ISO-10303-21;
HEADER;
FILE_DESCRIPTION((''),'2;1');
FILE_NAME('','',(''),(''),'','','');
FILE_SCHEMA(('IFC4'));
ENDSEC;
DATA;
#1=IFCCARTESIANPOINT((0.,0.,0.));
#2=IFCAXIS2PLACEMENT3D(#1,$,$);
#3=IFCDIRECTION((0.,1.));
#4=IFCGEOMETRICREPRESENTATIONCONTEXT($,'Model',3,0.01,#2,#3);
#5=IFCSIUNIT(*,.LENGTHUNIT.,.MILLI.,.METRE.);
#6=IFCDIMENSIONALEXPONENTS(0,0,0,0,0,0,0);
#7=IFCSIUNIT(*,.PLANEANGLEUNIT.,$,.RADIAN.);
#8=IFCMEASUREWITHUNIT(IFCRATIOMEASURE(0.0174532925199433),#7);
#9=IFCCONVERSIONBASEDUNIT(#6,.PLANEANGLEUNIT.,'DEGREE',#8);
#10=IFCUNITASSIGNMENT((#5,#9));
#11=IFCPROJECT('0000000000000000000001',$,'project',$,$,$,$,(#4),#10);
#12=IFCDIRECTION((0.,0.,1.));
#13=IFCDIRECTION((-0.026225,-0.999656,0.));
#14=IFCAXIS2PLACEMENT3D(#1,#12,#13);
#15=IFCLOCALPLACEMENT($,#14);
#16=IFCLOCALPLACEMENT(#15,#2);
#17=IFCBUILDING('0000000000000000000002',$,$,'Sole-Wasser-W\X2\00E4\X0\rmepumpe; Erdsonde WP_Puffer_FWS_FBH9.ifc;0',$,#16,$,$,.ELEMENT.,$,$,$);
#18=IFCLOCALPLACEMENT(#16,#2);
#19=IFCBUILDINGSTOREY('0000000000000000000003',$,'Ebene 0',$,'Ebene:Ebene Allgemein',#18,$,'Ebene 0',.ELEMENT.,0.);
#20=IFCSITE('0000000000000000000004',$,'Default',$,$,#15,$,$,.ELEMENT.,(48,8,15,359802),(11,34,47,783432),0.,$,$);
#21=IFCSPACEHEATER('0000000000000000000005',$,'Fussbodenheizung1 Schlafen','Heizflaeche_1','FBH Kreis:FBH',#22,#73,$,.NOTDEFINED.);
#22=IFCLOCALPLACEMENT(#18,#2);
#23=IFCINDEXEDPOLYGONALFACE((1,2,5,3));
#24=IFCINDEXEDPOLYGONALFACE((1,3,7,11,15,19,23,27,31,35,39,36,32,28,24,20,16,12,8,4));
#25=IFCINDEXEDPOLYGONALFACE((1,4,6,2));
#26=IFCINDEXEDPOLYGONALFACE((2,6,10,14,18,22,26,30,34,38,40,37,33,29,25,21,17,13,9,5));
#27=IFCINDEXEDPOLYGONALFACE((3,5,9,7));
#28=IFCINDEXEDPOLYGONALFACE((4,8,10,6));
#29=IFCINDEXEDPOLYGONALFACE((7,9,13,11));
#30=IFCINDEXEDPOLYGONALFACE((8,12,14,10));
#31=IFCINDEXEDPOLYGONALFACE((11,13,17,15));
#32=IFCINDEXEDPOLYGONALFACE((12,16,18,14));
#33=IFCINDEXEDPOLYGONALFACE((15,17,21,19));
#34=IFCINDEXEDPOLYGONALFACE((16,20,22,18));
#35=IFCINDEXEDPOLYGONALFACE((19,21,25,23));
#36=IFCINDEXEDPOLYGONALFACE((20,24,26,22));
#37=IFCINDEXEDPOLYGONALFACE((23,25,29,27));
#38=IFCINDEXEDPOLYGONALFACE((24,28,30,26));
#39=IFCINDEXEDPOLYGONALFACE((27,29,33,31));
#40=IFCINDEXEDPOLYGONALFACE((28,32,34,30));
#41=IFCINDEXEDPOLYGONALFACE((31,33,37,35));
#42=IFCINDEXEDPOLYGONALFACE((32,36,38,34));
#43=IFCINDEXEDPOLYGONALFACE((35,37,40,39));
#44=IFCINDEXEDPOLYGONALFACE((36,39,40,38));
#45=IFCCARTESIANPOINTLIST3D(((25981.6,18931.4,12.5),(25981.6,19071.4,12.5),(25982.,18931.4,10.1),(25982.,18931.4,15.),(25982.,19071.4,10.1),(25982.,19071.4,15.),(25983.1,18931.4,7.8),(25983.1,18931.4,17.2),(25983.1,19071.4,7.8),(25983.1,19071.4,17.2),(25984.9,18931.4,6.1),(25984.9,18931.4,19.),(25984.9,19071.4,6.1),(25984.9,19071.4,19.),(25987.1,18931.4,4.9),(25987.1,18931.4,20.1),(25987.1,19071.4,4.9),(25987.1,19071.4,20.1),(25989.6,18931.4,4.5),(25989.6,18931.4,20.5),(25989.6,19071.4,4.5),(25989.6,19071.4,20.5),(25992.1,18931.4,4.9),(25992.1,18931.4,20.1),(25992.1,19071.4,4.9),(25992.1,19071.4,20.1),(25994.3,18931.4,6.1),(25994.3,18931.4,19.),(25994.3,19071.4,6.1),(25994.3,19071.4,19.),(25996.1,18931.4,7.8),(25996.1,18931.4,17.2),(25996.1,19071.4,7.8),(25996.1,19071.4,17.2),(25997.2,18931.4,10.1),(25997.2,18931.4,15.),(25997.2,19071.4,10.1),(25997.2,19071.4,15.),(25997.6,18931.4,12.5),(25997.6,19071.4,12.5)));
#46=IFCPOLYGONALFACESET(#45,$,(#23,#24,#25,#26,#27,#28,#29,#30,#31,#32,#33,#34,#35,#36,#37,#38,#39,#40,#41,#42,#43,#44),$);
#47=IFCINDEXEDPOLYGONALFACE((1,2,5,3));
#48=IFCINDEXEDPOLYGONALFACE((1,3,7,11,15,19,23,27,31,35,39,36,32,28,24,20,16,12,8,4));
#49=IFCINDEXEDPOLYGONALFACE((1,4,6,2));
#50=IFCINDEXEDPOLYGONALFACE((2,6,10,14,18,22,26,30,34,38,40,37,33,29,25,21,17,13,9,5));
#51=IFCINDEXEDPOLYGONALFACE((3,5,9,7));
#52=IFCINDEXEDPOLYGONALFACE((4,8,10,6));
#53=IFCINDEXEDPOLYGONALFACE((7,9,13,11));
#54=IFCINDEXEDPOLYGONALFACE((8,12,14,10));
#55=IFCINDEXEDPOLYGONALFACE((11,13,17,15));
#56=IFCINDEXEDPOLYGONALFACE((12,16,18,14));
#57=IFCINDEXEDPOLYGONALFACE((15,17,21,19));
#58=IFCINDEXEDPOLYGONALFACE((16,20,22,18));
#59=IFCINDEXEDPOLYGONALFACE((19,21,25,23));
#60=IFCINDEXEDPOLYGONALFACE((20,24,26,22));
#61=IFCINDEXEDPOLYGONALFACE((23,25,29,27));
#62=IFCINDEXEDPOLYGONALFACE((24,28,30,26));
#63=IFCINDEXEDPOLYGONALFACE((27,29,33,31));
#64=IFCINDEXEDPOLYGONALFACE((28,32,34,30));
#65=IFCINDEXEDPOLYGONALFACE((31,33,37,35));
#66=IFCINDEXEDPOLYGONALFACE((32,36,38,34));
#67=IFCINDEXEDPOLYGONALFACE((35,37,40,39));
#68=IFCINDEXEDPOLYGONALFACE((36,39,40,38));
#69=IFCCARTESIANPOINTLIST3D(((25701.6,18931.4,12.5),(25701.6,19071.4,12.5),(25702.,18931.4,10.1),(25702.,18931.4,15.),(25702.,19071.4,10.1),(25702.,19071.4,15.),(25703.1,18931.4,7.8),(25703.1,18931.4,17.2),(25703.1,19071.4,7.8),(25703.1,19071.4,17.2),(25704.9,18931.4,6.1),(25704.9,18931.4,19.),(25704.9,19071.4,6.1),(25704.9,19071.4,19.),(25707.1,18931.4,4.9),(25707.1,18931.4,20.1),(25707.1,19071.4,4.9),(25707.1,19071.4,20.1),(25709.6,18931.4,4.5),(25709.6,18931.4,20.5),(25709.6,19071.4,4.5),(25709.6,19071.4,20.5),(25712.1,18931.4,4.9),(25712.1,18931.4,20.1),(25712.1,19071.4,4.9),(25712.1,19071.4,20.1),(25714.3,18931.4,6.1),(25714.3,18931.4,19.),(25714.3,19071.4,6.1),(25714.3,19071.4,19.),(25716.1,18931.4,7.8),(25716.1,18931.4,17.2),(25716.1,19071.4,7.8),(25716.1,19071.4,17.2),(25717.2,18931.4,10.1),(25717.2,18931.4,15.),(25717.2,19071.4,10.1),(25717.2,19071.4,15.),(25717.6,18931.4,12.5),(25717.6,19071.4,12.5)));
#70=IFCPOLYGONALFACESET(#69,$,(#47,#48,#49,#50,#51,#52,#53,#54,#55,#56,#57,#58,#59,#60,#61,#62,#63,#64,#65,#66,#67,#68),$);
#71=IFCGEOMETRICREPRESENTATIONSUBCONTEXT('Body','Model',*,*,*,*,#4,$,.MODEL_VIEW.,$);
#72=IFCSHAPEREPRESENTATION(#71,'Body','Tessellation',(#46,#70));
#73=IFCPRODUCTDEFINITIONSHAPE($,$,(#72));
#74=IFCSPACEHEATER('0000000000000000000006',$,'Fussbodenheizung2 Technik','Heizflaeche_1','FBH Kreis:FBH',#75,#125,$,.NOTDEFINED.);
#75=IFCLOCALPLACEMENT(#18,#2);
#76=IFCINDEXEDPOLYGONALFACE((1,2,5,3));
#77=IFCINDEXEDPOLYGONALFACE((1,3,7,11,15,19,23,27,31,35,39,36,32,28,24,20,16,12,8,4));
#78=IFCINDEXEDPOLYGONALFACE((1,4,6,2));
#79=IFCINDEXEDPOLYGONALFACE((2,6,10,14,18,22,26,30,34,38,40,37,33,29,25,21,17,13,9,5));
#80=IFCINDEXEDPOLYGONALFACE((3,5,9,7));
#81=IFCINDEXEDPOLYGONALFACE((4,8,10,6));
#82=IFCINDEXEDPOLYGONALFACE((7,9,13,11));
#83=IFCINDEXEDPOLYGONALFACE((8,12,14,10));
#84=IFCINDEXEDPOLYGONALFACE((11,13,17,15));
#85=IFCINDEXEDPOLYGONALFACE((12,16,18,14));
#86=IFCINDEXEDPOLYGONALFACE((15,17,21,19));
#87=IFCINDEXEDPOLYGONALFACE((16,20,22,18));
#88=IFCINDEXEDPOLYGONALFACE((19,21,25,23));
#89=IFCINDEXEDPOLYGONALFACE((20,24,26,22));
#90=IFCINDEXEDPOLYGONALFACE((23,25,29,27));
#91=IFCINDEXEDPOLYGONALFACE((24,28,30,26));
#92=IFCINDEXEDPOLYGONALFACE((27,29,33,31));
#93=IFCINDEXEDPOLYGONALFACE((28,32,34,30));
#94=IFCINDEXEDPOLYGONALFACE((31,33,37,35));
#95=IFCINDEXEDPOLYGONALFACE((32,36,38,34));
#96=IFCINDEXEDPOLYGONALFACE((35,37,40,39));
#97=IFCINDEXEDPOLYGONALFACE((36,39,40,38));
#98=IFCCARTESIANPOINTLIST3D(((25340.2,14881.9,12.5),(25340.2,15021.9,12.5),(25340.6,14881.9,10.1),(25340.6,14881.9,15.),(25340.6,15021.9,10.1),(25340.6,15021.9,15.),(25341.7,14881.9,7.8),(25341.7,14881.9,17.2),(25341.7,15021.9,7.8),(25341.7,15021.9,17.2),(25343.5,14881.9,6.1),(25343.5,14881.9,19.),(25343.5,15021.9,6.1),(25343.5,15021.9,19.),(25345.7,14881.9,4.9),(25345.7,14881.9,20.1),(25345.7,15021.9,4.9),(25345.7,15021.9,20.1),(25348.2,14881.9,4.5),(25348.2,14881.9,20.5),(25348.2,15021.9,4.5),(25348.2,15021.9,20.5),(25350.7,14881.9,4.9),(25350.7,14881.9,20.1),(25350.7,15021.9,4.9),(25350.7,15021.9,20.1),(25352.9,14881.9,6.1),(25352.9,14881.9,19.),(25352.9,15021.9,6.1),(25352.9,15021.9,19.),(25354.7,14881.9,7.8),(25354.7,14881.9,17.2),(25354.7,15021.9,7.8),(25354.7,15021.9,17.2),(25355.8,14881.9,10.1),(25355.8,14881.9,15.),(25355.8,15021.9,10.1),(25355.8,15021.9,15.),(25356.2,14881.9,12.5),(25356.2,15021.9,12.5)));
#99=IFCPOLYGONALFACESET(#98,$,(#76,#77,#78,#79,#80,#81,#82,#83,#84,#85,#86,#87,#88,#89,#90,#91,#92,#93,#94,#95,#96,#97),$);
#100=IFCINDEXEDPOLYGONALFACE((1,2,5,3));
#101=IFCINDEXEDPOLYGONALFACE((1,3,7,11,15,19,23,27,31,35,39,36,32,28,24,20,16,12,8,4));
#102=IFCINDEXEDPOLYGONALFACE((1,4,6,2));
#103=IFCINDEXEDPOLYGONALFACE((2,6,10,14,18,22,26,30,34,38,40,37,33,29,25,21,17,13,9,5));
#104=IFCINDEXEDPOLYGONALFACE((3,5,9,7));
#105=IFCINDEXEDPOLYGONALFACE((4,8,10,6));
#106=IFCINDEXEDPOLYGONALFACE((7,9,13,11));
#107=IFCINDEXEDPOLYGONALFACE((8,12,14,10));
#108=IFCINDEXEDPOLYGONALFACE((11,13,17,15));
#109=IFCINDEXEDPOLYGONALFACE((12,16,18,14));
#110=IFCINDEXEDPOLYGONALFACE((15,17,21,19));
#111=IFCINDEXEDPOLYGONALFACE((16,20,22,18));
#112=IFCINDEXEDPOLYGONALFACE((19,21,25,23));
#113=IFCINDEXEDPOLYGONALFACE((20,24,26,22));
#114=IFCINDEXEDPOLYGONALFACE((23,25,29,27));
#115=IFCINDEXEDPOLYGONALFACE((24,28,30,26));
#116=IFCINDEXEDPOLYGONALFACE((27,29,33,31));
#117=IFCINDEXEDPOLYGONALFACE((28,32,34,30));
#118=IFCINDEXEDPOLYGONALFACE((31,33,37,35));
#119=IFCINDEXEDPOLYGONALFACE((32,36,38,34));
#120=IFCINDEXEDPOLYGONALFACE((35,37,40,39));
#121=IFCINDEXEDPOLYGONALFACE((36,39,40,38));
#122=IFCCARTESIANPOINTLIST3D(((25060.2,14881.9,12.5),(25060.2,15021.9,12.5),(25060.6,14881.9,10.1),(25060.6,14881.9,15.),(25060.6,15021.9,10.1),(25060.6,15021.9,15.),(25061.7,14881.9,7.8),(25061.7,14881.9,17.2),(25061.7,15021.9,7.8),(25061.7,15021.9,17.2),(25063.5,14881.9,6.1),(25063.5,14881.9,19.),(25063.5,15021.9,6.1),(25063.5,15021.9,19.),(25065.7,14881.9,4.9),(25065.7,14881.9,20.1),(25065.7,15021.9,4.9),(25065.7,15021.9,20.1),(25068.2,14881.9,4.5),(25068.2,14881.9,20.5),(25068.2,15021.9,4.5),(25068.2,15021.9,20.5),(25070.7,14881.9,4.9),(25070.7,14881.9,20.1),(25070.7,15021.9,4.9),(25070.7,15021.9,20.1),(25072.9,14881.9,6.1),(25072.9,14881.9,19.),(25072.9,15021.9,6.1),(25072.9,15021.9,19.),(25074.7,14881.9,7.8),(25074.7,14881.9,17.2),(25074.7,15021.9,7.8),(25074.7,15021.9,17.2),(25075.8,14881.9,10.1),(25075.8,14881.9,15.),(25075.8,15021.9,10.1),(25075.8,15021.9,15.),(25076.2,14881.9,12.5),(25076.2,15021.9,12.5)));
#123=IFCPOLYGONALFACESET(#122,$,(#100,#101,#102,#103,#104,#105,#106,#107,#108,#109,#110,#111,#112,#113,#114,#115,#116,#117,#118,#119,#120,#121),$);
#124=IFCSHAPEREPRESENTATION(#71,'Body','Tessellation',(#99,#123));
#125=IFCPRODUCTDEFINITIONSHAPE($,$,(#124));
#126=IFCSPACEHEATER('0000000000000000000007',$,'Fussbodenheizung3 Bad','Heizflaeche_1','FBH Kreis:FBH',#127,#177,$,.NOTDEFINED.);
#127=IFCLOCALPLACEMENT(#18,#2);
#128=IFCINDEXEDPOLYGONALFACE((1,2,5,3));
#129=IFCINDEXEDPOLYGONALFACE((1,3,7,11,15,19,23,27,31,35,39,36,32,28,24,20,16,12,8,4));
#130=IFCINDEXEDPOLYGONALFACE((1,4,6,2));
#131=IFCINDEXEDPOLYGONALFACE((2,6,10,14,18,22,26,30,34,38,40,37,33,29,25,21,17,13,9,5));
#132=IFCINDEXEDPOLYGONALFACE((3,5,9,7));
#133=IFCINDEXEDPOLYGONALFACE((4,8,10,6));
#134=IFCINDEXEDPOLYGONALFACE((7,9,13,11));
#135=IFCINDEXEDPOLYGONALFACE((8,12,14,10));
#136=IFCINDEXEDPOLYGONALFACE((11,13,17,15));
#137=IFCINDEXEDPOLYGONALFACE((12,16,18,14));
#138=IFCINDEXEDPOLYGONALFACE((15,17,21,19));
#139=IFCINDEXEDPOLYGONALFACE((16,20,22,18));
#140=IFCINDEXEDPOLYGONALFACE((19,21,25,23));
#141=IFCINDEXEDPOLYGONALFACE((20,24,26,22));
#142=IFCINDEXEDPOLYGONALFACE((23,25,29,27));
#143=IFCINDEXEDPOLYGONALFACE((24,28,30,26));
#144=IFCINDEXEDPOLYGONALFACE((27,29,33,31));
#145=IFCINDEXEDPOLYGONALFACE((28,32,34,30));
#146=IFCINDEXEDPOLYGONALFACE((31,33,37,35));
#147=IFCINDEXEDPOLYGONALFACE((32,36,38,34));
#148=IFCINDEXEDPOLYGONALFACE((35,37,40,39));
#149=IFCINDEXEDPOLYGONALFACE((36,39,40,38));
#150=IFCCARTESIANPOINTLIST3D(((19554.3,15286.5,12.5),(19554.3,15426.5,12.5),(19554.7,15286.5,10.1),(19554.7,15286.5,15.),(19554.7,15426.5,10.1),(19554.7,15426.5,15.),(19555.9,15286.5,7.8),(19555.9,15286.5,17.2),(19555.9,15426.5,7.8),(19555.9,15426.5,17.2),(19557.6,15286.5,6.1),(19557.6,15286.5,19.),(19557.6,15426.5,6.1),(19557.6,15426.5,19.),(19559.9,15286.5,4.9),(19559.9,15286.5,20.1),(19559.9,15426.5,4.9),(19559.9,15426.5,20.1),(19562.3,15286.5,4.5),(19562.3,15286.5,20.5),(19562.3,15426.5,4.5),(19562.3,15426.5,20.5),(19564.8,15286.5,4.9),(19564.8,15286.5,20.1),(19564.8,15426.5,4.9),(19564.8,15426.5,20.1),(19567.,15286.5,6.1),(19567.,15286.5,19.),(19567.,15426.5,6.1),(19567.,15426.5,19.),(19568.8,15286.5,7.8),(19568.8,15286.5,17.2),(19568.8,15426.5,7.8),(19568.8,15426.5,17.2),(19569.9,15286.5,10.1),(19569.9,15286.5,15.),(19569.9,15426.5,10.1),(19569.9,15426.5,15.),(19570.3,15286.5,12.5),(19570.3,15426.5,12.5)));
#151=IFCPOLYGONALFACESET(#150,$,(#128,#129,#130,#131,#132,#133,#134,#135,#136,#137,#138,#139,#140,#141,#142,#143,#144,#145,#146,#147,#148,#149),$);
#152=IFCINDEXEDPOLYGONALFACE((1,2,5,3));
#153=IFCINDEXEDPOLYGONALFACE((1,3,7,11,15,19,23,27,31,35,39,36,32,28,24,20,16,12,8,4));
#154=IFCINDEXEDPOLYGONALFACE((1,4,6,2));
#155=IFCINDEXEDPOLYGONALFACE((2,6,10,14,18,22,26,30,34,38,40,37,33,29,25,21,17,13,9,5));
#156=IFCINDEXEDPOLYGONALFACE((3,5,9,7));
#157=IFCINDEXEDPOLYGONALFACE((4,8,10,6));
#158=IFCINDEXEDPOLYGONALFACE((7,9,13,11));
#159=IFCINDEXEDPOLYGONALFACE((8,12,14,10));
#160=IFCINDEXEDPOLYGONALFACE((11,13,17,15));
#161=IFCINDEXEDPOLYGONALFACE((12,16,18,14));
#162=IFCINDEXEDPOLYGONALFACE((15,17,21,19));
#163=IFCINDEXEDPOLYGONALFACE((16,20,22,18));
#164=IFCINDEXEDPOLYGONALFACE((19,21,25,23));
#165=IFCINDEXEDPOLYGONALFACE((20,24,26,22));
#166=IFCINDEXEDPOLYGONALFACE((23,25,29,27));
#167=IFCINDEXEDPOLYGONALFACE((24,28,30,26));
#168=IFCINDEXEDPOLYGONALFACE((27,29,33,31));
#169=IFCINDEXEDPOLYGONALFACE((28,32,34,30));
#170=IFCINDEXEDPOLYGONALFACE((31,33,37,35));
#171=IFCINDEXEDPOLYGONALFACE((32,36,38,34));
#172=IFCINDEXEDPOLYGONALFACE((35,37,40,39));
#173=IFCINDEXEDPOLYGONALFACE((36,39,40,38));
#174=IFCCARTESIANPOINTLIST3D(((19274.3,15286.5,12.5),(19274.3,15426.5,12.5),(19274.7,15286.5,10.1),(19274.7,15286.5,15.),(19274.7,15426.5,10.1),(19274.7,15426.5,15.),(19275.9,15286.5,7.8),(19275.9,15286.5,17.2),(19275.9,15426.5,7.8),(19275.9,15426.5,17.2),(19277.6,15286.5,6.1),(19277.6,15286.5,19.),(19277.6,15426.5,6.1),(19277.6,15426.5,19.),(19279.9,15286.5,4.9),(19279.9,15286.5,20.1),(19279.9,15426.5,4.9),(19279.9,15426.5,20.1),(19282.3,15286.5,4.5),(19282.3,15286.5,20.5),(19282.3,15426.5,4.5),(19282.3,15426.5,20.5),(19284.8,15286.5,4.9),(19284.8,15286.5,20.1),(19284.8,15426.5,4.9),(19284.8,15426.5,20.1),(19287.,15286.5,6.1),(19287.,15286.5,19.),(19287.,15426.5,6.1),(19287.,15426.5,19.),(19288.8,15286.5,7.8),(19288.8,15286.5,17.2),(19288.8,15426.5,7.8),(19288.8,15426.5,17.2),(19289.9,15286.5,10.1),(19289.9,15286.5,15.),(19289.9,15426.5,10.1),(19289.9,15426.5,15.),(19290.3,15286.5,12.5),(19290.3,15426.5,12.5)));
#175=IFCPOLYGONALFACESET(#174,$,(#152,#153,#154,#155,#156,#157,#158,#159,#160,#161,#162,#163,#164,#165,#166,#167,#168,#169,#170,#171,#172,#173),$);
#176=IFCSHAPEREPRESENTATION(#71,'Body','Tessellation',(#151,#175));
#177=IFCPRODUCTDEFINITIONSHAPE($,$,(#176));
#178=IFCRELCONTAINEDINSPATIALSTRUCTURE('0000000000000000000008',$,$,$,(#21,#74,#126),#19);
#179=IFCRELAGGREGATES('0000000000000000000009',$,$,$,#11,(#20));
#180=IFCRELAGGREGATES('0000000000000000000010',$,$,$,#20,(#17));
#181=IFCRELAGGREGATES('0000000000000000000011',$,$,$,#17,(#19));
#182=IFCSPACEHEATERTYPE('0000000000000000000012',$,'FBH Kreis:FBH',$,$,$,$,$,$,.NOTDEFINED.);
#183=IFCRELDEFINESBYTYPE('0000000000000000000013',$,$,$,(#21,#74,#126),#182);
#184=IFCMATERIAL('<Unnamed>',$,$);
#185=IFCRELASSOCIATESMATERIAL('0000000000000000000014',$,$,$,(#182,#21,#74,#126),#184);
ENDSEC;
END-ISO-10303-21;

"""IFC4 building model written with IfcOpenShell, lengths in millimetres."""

from ifc_helpers import new_model, entity, si_unit, converted_unit, direction, frame, origin, place, context, subcontext, project, spatial, indexed_curve, outline, extrude, source, transform, mapped, material, type_object, type_shapes, element, save


model = new_model("IFC4")

# Units and contexts
model_context = context("Model", 3, precision=0.01, world=origin(), true_north=direction((0.0, 1.0)))
body_context = subcontext(model_context, "Body", "Model", "MODEL_VIEW")
ifc_project = project(units=[si_unit("LENGTHUNIT", "METRE", prefix="MILLI"), converted_unit("PLANEANGLEUNIT", "DEGREE", entity("IfcRatioMeasure", 0.0174532925199433), si_unit("PLANEANGLEUNIT", "RADIAN"), dimensions=[0, 0, 0, 0, 0, 0, 0])], contexts=[model_context])

# Site, building, storey
site_placement = place(None, frame((0.0, 0.0, 0.0), z_axis=(0.0, 0.0, 1.0), x_axis=(-0.026225, -0.999656, 0.0)))
site = spatial("IfcSite", under=ifc_project, at=site_placement, Name="Default", CompositionType="ELEMENT", RefLatitude=(48, 8, 15, 359802), RefLongitude=(11, 34, 47, 783432), RefElevation=0.0)
building_placement = place(site_placement, origin())
building = spatial("IfcBuilding", under=site, at=building_placement, Description="Sole-Wasser-Wärmepumpe; Erdsonde WP_Puffer_FWS_FBH9.ifc;0", CompositionType="ELEMENT")
storey_placement = place(building_placement, origin())
storey = spatial("IfcBuildingStorey", under=building, at=storey_placement, Name="Ebene 0", ObjectType="Ebene:Ebene Allgemein", LongName="Ebene 0", CompositionType="ELEMENT", Elevation=0.0)

# Space heaters
ifc_material = material(Name="<Unnamed>")
space_heater_type = type_object("IfcSpaceHeaterType", Name="FBH Kreis:FBH", PredefinedType="NOTDEFINED", material=ifc_material)
shared_shape = source(origin(), body_context, "Body", "SweptSolid", [
    extrude(outline(indexed_curve([(8.0, 0.0), (7.6, 2.5), (6.5, 4.7), (4.7, 6.5), (2.5, 7.6), (0.0, 8.0), (-2.5, 7.6), (-4.7, 6.5), (-6.5, 4.7), (-7.6, 2.5), (-8.0, 0.0), (-7.6, -2.5), (-6.5, -4.7), (-4.7, -6.5), (-2.5, -7.6), (0.0, -8.0), (2.5, -7.6), (4.7, -6.5), (6.5, -4.7), (7.6, -2.5), (8.0, 0.0)], self_intersect=False)), frame((140.0, -1621.8, -83.0), z_axis=(0.0, 1.0, 0.0), x_axis=(1.0, 0.0, 0.0)), (0.0, 0.0, 1.0), 140.0),
    extrude(outline(indexed_curve([(8.0, 0.0), (7.6, 2.5), (6.5, 4.7), (4.7, 6.5), (2.5, 7.6), (0.0, 8.0), (-2.5, 7.6), (-4.7, 6.5), (-6.5, 4.7), (-7.6, 2.5), (-8.0, 0.0), (-7.6, -2.5), (-6.5, -4.7), (-4.7, -6.5), (-2.5, -7.6), (0.0, -8.0), (2.5, -7.6), (4.7, -6.5), (6.5, -4.7), (7.6, -2.5), (8.0, 0.0)], self_intersect=False)), frame((-140.0, -1621.8, -83.0), z_axis=(0.0, 1.0, 0.0), x_axis=(1.0, 0.0, 0.0)), (0.0, 0.0, 1.0), 140.0),
])
type_shapes(space_heater_type, [shared_shape])
for number, where, name in (
    (1, (25849.6, 20553.2, 95.5), "Fussbodenheizung1 Schlafen"),
    (2, (25208.2, 16503.6, 95.5), "Fussbodenheizung2 Technik"),
    (3, (19422.3, 16908.2, 95.5), "Fussbodenheizung3 Bad"),
):
    element("IfcSpaceHeater", number, at=place(storey_placement, frame(where)), inside=storey, type_object=space_heater_type, material=ifc_material, Name=name, Description="Heizflaeche_1", ObjectType="FBH Kreis:FBH", PredefinedType="NOTDEFINED", context=body_context, shape_type="MappedRepresentation", body=[
        mapped(shared_shape, transform((0.0, 0.0, 0.0), scale=1.0)),
    ])

save(model, "model.ifc")
